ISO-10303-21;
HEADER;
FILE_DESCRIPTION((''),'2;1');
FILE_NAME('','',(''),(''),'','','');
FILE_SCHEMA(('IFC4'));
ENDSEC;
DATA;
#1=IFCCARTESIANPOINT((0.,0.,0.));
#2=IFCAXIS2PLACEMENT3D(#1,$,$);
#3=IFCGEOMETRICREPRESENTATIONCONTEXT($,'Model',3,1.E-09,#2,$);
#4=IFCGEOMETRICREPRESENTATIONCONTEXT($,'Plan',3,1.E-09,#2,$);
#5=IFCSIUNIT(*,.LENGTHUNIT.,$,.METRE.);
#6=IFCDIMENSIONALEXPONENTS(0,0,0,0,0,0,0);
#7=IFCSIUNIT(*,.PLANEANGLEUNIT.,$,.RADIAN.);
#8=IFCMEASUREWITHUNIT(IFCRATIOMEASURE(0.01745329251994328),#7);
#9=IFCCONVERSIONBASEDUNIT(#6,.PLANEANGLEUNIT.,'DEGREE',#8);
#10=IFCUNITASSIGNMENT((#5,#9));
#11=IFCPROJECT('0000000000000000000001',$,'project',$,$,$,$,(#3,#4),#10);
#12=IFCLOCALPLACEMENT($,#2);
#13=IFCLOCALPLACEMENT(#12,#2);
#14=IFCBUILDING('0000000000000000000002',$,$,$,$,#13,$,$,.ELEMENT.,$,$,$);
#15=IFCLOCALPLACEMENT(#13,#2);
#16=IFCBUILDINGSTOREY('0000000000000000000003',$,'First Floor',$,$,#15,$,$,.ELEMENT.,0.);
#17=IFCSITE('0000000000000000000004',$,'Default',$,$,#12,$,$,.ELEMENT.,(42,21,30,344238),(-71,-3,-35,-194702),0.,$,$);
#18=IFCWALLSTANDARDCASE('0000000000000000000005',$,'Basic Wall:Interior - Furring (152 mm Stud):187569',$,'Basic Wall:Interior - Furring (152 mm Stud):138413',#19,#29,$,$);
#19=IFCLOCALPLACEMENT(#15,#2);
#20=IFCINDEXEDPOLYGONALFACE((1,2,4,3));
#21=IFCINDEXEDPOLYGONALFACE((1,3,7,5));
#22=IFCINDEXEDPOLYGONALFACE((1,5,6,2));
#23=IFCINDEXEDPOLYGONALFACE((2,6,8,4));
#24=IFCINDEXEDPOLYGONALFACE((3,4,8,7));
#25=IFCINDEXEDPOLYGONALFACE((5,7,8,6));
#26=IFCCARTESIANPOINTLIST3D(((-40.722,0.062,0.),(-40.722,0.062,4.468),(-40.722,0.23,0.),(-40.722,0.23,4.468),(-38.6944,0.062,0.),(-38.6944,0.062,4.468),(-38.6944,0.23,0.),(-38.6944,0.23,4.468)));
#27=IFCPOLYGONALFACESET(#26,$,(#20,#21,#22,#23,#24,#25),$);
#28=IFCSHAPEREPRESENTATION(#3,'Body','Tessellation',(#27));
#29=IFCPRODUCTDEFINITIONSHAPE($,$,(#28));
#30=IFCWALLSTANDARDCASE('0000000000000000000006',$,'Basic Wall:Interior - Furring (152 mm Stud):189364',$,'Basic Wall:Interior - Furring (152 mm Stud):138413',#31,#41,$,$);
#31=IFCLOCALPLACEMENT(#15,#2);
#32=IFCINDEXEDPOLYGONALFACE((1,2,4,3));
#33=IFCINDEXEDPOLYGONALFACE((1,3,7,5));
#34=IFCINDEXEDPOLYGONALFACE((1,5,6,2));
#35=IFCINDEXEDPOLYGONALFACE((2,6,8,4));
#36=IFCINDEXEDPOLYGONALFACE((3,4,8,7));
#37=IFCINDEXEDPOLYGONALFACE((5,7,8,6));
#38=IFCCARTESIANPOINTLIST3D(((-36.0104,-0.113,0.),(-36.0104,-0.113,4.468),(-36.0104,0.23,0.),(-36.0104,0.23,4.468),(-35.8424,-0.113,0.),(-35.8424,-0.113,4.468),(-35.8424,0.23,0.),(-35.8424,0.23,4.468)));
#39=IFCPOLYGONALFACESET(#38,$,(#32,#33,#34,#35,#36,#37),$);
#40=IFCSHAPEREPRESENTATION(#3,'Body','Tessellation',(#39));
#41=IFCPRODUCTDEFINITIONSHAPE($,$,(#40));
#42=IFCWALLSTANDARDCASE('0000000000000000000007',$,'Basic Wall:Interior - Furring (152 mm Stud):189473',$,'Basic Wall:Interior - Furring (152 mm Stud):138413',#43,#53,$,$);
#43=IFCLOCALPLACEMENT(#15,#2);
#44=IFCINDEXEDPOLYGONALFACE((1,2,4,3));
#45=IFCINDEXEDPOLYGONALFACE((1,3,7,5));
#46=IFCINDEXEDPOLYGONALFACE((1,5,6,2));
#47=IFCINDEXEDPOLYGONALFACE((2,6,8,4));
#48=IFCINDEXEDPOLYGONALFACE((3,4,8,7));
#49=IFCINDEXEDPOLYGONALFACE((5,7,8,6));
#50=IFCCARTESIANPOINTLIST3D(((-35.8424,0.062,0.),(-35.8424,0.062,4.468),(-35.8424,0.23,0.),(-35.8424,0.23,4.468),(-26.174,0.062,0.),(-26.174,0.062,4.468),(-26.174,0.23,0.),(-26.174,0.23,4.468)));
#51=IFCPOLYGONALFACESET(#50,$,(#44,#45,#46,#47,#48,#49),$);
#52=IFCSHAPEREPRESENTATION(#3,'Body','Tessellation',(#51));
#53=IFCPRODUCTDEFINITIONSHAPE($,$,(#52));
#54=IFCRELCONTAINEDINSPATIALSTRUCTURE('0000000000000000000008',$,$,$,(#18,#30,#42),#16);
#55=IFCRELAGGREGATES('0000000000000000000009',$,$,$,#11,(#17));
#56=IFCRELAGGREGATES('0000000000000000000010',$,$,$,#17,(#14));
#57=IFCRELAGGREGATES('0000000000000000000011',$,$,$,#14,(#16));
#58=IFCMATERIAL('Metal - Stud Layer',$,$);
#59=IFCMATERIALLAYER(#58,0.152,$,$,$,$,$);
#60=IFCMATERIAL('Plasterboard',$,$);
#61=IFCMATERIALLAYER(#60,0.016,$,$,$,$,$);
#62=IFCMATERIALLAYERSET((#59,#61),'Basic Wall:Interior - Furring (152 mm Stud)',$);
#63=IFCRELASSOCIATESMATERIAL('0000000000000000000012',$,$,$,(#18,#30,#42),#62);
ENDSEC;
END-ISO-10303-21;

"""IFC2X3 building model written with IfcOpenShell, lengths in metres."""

from ifc_helpers import new_model, entity, si_unit, converted_unit, frame, frame_2d, origin, place, context, project, spatial, rectangle, extrude, material, layer, layer_set, layer_usage, element, save


model = new_model("IFC2X3")

# Units and contexts
model_context = context("Model", 3, precision=1e-09, world=origin())
plan_context = context("Plan", 3, precision=1e-09, world=origin())
ifc_project = project(units=[si_unit("LENGTHUNIT", "METRE"), converted_unit("PLANEANGLEUNIT", "DEGREE", entity("IfcRatioMeasure", 0.01745329251994328), si_unit("PLANEANGLEUNIT", "RADIAN"), dimensions=[0, 0, 0, 0, 0, 0, 0])], contexts=[model_context, plan_context])

# Site, building, storey
site_placement = place(None, origin())
site = spatial("IfcSite", under=ifc_project, at=site_placement, Name="Default", CompositionType="ELEMENT", RefLatitude=(42, 21, 30, 344238), RefLongitude=(-71, -3, -35, -194702), RefElevation=0.0)
building_placement = place(site_placement, origin())
building = spatial("IfcBuilding", under=site, at=building_placement, CompositionType="ELEMENT")
storey_placement = place(building_placement, origin())
storey = spatial("IfcBuildingStorey", under=building, at=storey_placement, Name="First Floor", CompositionType="ELEMENT", Elevation=0.0)

# Walls
ifc_material_1 = material(Name="Plasterboard")
ifc_material_2 = material(Name="Metal - Stud Layer")
ifc_layer_1 = layer(ifc_material_2, 0.152)
ifc_layer_2 = layer(ifc_material_1, 0.016)
ifc_layer_set_1 = layer_set([ifc_layer_1, ifc_layer_2], Name="Basic Wall:Interior - Furring (152 mm Stud)")
ifc_layer_usage_1 = layer_usage(ifc_layer_set_1, "AXIS2", "POSITIVE", -0.084)
wall_1_placement = place(storey_placement, frame((-40.722, 0.146, 0.0)))
element("IfcWallStandardCase", 1, at=wall_1_placement, inside=storey, material=ifc_layer_usage_1, Name="Basic Wall:Interior - Furring (152 mm Stud):187569", ObjectType="Basic Wall:Interior - Furring (152 mm Stud):138413", context=model_context, shape_type="SweptSolid", body=[
    extrude(rectangle(XDim=2.0276, YDim=0.168, at=frame_2d((1.0138, 0.0), x_axis=(-1.0, 0.0))), origin(), (0.0, 0.0, 1.0), 4.468),
])
wall_2_placement = place(storey_placement, frame((-35.9264, -0.113, 0.0), z_axis=(0.0, 0.0, 1.0), x_axis=(0.0, 1.0, 0.0)))
element("IfcWallStandardCase", 2, at=wall_2_placement, inside=storey, material=ifc_layer_usage_1, Name="Basic Wall:Interior - Furring (152 mm Stud):189364", ObjectType="Basic Wall:Interior - Furring (152 mm Stud):138413", context=model_context, shape_type="SweptSolid", body=[
    extrude(rectangle(XDim=0.343, YDim=0.168, at=frame_2d((0.1715, 0.0), x_axis=(-1.0, 0.0))), origin(), (0.0, 0.0, 1.0), 4.468),
])
wall_3_placement = place(storey_placement, frame((-35.8424, 0.146, 0.0)))
element("IfcWallStandardCase", 3, at=wall_3_placement, inside=storey, material=ifc_layer_usage_1, Name="Basic Wall:Interior - Furring (152 mm Stud):189473", ObjectType="Basic Wall:Interior - Furring (152 mm Stud):138413", context=model_context, shape_type="SweptSolid", body=[
    extrude(rectangle(XDim=9.6684, YDim=0.168, at=frame_2d((4.8342, 0.0), x_axis=(-1.0, 0.0))), origin(), (0.0, 0.0, 1.0), 4.468),
])

save(model, "model.ifc")
